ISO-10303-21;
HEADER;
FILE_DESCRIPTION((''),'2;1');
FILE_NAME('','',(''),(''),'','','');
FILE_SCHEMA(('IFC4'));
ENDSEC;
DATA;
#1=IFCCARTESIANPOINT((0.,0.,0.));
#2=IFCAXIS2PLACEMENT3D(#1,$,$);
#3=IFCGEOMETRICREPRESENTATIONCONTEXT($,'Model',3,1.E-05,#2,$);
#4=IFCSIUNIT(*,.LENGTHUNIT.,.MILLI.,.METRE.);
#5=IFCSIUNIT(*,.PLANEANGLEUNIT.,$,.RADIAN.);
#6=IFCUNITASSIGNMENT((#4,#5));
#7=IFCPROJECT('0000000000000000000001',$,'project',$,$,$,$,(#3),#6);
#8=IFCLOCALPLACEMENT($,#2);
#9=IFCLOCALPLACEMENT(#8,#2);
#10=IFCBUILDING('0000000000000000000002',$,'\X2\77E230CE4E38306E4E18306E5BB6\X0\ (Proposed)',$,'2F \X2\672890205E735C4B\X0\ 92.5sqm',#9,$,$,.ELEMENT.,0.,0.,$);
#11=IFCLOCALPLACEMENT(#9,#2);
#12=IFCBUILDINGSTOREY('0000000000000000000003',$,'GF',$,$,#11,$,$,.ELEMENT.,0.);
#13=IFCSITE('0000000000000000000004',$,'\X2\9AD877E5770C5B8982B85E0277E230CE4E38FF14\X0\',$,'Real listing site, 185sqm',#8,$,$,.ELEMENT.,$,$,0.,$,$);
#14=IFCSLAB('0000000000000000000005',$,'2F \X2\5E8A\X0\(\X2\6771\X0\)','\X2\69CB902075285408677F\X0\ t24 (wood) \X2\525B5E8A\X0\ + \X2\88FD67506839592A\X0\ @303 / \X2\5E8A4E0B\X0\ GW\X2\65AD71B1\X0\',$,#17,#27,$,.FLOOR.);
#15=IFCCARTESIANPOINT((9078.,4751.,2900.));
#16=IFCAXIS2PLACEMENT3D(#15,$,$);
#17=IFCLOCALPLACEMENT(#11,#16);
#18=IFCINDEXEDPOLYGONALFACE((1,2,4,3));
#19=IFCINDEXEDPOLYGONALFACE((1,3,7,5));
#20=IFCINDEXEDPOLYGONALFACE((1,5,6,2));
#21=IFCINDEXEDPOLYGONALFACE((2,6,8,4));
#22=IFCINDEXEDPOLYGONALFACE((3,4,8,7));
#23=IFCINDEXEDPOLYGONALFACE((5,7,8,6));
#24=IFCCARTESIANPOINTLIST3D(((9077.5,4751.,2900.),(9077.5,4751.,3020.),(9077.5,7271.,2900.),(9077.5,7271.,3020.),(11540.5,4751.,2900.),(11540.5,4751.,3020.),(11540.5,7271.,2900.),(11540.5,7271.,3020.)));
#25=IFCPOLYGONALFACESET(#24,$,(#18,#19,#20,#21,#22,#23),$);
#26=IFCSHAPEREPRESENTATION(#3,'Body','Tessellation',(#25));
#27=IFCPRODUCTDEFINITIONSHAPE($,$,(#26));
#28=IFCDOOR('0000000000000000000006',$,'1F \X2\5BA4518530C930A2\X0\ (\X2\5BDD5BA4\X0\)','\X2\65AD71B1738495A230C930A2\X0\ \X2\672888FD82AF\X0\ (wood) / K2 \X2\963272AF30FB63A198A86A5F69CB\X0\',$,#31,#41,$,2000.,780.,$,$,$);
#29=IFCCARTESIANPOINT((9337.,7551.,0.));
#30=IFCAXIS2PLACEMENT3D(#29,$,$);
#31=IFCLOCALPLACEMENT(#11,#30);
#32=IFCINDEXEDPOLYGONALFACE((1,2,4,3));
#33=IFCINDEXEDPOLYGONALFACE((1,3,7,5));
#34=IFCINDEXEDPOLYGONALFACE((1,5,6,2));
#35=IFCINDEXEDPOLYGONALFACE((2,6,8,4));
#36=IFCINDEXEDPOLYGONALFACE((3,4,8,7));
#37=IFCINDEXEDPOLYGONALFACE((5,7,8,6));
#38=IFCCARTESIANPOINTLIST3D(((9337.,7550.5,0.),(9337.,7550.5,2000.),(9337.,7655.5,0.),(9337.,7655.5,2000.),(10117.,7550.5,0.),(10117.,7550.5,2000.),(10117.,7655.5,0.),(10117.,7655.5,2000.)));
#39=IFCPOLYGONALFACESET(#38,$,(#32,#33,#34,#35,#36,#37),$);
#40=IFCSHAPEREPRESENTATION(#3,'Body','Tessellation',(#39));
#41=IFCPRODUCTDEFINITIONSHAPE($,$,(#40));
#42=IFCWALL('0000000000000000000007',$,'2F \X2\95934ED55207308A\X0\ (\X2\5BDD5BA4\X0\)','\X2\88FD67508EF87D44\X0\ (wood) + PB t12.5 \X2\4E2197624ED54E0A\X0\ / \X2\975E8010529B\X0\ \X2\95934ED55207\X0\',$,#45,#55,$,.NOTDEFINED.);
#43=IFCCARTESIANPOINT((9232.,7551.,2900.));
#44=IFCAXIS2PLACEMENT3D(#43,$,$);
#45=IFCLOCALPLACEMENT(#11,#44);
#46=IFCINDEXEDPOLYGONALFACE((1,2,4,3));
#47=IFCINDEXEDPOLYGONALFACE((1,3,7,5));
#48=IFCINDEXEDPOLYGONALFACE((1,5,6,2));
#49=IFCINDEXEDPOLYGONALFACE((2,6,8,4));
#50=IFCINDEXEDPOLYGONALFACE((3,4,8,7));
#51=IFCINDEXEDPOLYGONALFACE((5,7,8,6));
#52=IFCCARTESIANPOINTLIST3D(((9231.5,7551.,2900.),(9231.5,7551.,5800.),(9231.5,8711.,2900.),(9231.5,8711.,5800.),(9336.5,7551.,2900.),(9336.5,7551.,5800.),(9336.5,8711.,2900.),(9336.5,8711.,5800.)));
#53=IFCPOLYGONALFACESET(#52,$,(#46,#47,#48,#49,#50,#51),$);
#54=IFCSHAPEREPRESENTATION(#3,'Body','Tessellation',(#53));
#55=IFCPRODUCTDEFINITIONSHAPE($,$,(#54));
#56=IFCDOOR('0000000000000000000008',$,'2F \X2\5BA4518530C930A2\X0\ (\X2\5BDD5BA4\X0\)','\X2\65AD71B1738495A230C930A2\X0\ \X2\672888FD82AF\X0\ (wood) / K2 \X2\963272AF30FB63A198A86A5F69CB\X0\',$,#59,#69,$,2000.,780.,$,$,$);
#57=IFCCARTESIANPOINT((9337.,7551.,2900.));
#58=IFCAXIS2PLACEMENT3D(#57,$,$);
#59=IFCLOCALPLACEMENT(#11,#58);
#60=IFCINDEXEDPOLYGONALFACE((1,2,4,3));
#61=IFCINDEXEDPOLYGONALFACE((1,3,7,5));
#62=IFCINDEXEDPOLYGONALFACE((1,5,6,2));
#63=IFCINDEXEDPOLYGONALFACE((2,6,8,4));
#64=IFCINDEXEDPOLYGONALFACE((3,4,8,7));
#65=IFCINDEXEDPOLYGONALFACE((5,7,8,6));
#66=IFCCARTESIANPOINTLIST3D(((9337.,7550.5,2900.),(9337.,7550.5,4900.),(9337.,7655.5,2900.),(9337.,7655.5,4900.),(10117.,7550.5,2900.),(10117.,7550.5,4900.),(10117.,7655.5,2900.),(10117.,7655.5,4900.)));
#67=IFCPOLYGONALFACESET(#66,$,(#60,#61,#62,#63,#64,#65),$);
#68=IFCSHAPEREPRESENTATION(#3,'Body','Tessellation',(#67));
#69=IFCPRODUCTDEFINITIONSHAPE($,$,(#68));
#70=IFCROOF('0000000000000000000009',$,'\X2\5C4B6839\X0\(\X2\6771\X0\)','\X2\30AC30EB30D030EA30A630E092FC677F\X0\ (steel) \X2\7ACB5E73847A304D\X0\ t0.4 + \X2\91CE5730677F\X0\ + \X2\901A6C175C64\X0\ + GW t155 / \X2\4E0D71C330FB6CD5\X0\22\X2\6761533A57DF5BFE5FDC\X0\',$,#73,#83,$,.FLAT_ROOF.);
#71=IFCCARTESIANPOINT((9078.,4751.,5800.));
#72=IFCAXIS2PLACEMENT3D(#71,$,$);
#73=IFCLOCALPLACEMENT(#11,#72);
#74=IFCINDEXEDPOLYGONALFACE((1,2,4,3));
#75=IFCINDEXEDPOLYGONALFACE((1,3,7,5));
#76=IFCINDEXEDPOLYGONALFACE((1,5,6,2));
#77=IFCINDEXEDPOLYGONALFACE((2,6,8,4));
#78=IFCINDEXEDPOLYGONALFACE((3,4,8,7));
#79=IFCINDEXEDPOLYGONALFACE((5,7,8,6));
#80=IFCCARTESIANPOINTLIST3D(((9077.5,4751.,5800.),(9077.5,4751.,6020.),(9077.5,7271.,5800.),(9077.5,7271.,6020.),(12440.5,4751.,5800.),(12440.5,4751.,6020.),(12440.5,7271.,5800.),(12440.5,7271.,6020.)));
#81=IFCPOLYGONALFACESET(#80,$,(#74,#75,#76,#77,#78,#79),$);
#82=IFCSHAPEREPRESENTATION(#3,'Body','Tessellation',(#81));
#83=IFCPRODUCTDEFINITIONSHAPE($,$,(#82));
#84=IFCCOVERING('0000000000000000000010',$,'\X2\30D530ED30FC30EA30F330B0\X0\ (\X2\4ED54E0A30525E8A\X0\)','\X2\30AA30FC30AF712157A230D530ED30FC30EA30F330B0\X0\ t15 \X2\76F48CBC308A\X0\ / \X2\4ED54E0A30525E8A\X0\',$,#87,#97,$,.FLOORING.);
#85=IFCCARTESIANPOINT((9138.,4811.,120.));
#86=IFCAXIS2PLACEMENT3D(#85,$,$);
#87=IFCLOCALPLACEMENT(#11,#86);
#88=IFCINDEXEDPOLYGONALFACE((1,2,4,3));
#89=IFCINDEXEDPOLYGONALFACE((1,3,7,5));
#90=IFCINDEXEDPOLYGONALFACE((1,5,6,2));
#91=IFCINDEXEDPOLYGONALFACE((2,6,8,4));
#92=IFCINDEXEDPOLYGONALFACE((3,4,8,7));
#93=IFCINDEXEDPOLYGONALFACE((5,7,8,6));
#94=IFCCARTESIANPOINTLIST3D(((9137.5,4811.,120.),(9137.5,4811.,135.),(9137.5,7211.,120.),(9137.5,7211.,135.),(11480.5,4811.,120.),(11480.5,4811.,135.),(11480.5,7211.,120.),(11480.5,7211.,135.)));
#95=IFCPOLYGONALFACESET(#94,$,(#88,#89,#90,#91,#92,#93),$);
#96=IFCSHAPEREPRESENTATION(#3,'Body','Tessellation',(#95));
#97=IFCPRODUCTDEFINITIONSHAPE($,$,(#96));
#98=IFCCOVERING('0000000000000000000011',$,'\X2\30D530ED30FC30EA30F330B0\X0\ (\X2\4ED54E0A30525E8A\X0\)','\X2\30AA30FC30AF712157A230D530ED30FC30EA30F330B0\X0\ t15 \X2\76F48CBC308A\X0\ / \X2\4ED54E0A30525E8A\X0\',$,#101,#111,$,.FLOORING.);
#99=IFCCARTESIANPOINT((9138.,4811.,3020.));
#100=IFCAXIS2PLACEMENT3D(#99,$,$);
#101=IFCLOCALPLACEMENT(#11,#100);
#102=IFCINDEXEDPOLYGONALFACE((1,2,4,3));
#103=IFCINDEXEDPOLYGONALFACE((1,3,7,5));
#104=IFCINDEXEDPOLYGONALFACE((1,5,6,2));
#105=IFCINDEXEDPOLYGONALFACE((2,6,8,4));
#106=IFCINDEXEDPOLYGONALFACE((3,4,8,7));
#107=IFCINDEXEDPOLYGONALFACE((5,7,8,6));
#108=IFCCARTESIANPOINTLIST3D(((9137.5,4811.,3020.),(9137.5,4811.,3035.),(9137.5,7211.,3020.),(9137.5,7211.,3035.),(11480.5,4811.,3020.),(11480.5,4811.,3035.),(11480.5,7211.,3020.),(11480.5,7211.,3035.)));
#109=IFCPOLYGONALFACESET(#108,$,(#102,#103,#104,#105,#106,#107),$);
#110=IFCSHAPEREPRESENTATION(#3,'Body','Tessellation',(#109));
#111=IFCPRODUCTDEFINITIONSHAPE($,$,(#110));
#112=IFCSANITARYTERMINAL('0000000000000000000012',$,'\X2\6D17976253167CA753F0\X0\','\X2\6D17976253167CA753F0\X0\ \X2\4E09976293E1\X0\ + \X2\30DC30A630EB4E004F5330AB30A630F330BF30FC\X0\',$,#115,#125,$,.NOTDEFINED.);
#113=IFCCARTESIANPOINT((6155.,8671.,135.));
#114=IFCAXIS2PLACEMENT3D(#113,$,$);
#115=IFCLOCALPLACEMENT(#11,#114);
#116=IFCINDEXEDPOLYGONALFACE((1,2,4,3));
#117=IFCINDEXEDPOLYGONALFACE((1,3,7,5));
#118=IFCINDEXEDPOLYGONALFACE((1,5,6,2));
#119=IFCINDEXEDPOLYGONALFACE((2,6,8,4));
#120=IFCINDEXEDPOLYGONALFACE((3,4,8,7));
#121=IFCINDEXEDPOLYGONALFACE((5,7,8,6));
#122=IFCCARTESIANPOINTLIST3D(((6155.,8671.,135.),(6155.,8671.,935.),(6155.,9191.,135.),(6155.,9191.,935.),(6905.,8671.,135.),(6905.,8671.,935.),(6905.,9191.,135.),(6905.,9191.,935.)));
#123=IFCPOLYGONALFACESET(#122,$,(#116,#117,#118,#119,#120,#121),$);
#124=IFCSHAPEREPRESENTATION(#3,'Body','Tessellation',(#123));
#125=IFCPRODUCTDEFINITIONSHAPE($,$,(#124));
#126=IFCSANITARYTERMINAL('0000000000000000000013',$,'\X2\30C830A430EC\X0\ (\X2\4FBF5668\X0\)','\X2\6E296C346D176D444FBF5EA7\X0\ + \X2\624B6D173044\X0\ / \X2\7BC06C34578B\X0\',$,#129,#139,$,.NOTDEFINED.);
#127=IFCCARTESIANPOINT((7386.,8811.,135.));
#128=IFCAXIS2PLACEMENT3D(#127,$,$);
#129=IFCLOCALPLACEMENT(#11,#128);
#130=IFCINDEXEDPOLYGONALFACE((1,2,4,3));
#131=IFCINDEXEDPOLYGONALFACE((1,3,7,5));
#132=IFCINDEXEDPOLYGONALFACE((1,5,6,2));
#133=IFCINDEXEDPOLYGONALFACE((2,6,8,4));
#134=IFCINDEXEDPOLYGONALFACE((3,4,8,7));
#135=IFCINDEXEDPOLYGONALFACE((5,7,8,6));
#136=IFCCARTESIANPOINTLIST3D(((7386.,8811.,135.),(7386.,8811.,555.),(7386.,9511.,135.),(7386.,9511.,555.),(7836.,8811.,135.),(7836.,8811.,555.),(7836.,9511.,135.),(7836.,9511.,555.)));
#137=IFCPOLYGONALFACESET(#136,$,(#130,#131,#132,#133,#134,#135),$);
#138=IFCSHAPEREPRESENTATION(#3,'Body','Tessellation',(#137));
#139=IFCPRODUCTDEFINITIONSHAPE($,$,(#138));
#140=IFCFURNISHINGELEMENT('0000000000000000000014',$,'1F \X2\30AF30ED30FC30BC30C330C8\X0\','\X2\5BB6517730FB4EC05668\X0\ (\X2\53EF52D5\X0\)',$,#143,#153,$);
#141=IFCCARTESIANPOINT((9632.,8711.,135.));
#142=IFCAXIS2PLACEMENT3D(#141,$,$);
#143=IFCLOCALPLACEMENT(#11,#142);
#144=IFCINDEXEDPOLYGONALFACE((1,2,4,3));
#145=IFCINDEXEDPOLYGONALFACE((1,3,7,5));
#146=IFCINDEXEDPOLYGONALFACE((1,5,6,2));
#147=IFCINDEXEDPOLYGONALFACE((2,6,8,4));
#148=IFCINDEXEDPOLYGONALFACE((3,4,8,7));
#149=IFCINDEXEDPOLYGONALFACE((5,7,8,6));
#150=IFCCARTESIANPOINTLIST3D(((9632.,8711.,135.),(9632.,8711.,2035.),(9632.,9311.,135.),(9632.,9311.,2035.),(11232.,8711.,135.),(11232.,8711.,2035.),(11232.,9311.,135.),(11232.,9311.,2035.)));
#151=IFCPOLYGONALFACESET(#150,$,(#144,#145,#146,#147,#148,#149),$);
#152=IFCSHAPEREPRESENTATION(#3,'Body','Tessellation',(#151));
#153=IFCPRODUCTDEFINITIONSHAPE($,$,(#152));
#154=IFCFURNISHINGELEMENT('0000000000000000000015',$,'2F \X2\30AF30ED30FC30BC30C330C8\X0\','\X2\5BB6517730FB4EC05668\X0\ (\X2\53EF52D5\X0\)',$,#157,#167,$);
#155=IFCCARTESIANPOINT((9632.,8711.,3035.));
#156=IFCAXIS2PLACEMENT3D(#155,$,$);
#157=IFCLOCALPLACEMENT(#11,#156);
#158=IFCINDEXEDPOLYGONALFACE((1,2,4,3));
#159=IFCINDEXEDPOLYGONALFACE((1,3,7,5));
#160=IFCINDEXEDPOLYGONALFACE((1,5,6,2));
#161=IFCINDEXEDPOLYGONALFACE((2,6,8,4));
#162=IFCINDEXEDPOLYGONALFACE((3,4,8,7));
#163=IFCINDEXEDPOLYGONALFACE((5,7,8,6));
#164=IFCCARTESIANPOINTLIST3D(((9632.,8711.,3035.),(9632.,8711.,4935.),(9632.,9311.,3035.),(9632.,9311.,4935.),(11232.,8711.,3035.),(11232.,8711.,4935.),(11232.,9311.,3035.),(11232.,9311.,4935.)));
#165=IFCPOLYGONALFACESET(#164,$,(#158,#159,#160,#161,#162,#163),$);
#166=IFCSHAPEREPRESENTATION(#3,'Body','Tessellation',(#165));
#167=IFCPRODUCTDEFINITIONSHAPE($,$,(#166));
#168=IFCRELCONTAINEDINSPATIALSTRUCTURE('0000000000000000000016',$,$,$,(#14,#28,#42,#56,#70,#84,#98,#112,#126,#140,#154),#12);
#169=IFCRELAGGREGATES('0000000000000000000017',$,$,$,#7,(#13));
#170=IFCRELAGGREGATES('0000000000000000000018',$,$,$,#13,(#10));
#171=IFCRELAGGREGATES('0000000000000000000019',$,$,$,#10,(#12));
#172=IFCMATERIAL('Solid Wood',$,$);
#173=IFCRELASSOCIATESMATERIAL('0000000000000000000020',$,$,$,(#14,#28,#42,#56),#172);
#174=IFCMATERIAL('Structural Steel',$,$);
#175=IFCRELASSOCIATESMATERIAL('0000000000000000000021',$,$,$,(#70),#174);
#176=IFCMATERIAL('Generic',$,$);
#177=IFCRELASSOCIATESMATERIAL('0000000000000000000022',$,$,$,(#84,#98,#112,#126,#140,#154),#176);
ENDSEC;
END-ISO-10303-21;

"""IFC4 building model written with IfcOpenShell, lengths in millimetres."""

from ifc_helpers import new_model, si_unit, frame, frame_2d, origin, place, context, project, spatial, rectangle, extrude, material, element, save


model = new_model("IFC4")

# Units and contexts
model_context = context("Model", 3, precision=1e-05, world=origin())
ifc_project = project(units=[si_unit("LENGTHUNIT", "METRE", prefix="MILLI"), si_unit("PLANEANGLEUNIT", "RADIAN")], contexts=[model_context])

# Site, building, storey
site_placement = place(None, origin())
site = spatial("IfcSite", under=ifc_project, at=site_placement, Name="高知県安芸市矢ノ丸４", ObjectType="Real listing site, 185sqm", CompositionType="ELEMENT", RefElevation=0.0)
building_placement = place(site_placement, origin())
building = spatial("IfcBuilding", under=site, at=building_placement, Name="矢ノ丸の丘の家 (Proposed)", ObjectType="2F 木造平屋 92.5sqm", CompositionType="ELEMENT", ElevationOfRefHeight=0.0, ElevationOfTerrain=0.0)
storey_placement = place(building_placement, origin())
storey = spatial("IfcBuildingStorey", under=building, at=storey_placement, Name="GF", CompositionType="ELEMENT", Elevation=0.0)

# Slab
ifc_material_1 = material(Name="Solid Wood")
slab_1_placement = place(storey_placement, frame((9078.0, 4751.0, 2900.0)))
element("IfcSlab", 1, at=slab_1_placement, inside=storey, material=ifc_material_1, Name="2F 床(東)", Description="構造用合板 t24 (wood) 剛床 + 製材根太 @303 / 床下 GW断熱", PredefinedType="FLOOR", context=model_context, shape_type="SweptSolid", body=[
    extrude(rectangle(XDim=2463.0, YDim=2520.0, at=frame_2d((1231.0, 1260.0))), frame((9078.0, 4751.0, 2900.0)), (0.0, 0.0, 1.0), 120.0),
])

# Door
door_1_placement = place(storey_placement, frame((9337.0, 7551.0, 0.0)))
element("IfcDoor", 2, at=door_1_placement, inside=storey, material=ifc_material_1, Name="1F 室内ドア (寝室)", Description="断熱玄関ドア 木製芯 (wood) / K2 防犯・採風機構", OverallHeight=2000.0, OverallWidth=780.0, context=model_context, shape_type="SweptSolid", body=[
    extrude(rectangle(XDim=780.0, YDim=105.0, at=frame_2d((390.0, 52.0))), frame((9337.0, 7551.0, 0.0)), (0.0, 0.0, 1.0), 2000.0),
])

# Wall
wall_1_placement = place(storey_placement, frame((9232.0, 7551.0, 2900.0)))
element("IfcWall", 3, at=wall_1_placement, inside=storey, material=ifc_material_1, Name="2F 間仕切り (寝室)", Description="製材軸組 (wood) + PB t12.5 両面仕上 / 非耐力 間仕切", PredefinedType="NOTDEFINED", context=model_context, shape_type="SweptSolid", body=[
    extrude(rectangle(XDim=105.0, YDim=1160.0, at=frame_2d((52.0, 580.0))), frame((9232.0, 7551.0, 2900.0)), (0.0, 0.0, 1.0), 2900.0),
])

# Door
door_2_placement = place(storey_placement, frame((9337.0, 7551.0, 2900.0)))
element("IfcDoor", 4, at=door_2_placement, inside=storey, material=ifc_material_1, Name="2F 室内ドア (寝室)", Description="断熱玄関ドア 木製芯 (wood) / K2 防犯・採風機構", OverallHeight=2000.0, OverallWidth=780.0, context=model_context, shape_type="SweptSolid", body=[
    extrude(rectangle(XDim=780.0, YDim=105.0, at=frame_2d((390.0, 52.0))), frame((9337.0, 7551.0, 2900.0)), (0.0, 0.0, 1.0), 2000.0),
])

# Roof
ifc_material_2 = material(Name="Structural Steel")
for number, where, name in (
    (5, (9078.0, 4751.0, 5800.0), "屋根(東)"),
):
    element("IfcRoof", number, at=place(storey_placement, frame(where)), inside=storey, material=ifc_material_2, Name=name, Description="ガルバリウム鋼板 (steel) 立平葺き t0.4 + 野地板 + 通気層 + GW t155 / 不燃・法22条区域対応", PredefinedType="FLAT_ROOF", context=model_context, shape_type="SweptSolid", body=[
        extrude(rectangle(XDim=3363.0, YDim=2520.0, at=frame_2d((1681.0, 1260.0))), frame((9078.0, 4751.0, 5800.0)), (0.0, 0.0, 1.0), 220.0),
    ])

# Coverings
ifc_material_3 = material(Name="Generic")
covering_1_placement = place(storey_placement, frame((9138.0, 4811.0, 120.0)))
element("IfcCovering", 6, at=covering_1_placement, inside=storey, material=ifc_material_3, Name="フローリング (仕上げ床)", Description="オーク無垢フローリング t15 直貼り / 仕上げ床", PredefinedType="FLOORING", context=model_context, shape_type="SweptSolid", body=[
    extrude(rectangle(XDim=2343.0, YDim=2400.0, at=frame_2d((1171.0, 1200.0))), frame((9138.0, 4811.0, 120.0)), (0.0, 0.0, 1.0), 15.0),
])
covering_2_placement = place(storey_placement, frame((9138.0, 4811.0, 3020.0)))
element("IfcCovering", 7, at=covering_2_placement, inside=storey, material=ifc_material_3, Name="フローリング (仕上げ床)", Description="オーク無垢フローリング t15 直貼り / 仕上げ床", PredefinedType="FLOORING", context=model_context, shape_type="SweptSolid", body=[
    extrude(rectangle(XDim=2343.0, YDim=2400.0, at=frame_2d((1171.0, 1200.0))), frame((9138.0, 4811.0, 3020.0)), (0.0, 0.0, 1.0), 15.0),
])

# Sanitary terminals
sanitary_terminal_1_placement = place(storey_placement, frame((6155.0, 8671.0, 135.0)))
element("IfcSanitaryTerminal", 8, at=sanitary_terminal_1_placement, inside=storey, material=ifc_material_3, Name="洗面化粧台", Description="洗面化粧台 三面鏡 + ボウル一体カウンター", PredefinedType="NOTDEFINED", context=model_context, shape_type="SweptSolid", body=[
    extrude(rectangle(XDim=750.0, YDim=520.0, at=frame_2d((375.0, 260.0))), frame((6155.0, 8671.0, 135.0)), (0.0, 0.0, 1.0), 800.0),
])
sanitary_terminal_2_placement = place(storey_placement, frame((7386.0, 8811.0, 135.0)))
element("IfcSanitaryTerminal", 9, at=sanitary_terminal_2_placement, inside=storey, material=ifc_material_3, Name="トイレ (便器)", Description="温水洗浄便座 + 手洗い / 節水型", PredefinedType="NOTDEFINED", context=model_context, shape_type="SweptSolid", body=[
    extrude(rectangle(XDim=450.0, YDim=700.0, at=frame_2d((225.0, 350.0))), frame((7386.0, 8811.0, 135.0)), (0.0, 0.0, 1.0), 420.0),
])

# Furnishing elements
furnishing_1_placement = place(storey_placement, frame((9632.0, 8711.0, 135.0)))
element("IfcFurnishingElement", 10, at=furnishing_1_placement, inside=storey, material=ifc_material_3, Name="1F クローゼット", Description="家具・什器 (可動)", context=model_context, shape_type="SweptSolid", body=[
    extrude(rectangle(XDim=1600.0, YDim=600.0, at=frame_2d((800.0, 300.0))), frame((9632.0, 8711.0, 135.0)), (0.0, 0.0, 1.0), 1900.0),
])
furnishing_2_placement = place(storey_placement, frame((9632.0, 8711.0, 3035.0)))
element("IfcFurnishingElement", 11, at=furnishing_2_placement, inside=storey, material=ifc_material_3, Name="2F クローゼット", Description="家具・什器 (可動)", context=model_context, shape_type="SweptSolid", body=[
    extrude(rectangle(XDim=1600.0, YDim=600.0, at=frame_2d((800.0, 300.0))), frame((9632.0, 8711.0, 3035.0)), (0.0, 0.0, 1.0), 1900.0),
])

save(model, "model.ifc")
